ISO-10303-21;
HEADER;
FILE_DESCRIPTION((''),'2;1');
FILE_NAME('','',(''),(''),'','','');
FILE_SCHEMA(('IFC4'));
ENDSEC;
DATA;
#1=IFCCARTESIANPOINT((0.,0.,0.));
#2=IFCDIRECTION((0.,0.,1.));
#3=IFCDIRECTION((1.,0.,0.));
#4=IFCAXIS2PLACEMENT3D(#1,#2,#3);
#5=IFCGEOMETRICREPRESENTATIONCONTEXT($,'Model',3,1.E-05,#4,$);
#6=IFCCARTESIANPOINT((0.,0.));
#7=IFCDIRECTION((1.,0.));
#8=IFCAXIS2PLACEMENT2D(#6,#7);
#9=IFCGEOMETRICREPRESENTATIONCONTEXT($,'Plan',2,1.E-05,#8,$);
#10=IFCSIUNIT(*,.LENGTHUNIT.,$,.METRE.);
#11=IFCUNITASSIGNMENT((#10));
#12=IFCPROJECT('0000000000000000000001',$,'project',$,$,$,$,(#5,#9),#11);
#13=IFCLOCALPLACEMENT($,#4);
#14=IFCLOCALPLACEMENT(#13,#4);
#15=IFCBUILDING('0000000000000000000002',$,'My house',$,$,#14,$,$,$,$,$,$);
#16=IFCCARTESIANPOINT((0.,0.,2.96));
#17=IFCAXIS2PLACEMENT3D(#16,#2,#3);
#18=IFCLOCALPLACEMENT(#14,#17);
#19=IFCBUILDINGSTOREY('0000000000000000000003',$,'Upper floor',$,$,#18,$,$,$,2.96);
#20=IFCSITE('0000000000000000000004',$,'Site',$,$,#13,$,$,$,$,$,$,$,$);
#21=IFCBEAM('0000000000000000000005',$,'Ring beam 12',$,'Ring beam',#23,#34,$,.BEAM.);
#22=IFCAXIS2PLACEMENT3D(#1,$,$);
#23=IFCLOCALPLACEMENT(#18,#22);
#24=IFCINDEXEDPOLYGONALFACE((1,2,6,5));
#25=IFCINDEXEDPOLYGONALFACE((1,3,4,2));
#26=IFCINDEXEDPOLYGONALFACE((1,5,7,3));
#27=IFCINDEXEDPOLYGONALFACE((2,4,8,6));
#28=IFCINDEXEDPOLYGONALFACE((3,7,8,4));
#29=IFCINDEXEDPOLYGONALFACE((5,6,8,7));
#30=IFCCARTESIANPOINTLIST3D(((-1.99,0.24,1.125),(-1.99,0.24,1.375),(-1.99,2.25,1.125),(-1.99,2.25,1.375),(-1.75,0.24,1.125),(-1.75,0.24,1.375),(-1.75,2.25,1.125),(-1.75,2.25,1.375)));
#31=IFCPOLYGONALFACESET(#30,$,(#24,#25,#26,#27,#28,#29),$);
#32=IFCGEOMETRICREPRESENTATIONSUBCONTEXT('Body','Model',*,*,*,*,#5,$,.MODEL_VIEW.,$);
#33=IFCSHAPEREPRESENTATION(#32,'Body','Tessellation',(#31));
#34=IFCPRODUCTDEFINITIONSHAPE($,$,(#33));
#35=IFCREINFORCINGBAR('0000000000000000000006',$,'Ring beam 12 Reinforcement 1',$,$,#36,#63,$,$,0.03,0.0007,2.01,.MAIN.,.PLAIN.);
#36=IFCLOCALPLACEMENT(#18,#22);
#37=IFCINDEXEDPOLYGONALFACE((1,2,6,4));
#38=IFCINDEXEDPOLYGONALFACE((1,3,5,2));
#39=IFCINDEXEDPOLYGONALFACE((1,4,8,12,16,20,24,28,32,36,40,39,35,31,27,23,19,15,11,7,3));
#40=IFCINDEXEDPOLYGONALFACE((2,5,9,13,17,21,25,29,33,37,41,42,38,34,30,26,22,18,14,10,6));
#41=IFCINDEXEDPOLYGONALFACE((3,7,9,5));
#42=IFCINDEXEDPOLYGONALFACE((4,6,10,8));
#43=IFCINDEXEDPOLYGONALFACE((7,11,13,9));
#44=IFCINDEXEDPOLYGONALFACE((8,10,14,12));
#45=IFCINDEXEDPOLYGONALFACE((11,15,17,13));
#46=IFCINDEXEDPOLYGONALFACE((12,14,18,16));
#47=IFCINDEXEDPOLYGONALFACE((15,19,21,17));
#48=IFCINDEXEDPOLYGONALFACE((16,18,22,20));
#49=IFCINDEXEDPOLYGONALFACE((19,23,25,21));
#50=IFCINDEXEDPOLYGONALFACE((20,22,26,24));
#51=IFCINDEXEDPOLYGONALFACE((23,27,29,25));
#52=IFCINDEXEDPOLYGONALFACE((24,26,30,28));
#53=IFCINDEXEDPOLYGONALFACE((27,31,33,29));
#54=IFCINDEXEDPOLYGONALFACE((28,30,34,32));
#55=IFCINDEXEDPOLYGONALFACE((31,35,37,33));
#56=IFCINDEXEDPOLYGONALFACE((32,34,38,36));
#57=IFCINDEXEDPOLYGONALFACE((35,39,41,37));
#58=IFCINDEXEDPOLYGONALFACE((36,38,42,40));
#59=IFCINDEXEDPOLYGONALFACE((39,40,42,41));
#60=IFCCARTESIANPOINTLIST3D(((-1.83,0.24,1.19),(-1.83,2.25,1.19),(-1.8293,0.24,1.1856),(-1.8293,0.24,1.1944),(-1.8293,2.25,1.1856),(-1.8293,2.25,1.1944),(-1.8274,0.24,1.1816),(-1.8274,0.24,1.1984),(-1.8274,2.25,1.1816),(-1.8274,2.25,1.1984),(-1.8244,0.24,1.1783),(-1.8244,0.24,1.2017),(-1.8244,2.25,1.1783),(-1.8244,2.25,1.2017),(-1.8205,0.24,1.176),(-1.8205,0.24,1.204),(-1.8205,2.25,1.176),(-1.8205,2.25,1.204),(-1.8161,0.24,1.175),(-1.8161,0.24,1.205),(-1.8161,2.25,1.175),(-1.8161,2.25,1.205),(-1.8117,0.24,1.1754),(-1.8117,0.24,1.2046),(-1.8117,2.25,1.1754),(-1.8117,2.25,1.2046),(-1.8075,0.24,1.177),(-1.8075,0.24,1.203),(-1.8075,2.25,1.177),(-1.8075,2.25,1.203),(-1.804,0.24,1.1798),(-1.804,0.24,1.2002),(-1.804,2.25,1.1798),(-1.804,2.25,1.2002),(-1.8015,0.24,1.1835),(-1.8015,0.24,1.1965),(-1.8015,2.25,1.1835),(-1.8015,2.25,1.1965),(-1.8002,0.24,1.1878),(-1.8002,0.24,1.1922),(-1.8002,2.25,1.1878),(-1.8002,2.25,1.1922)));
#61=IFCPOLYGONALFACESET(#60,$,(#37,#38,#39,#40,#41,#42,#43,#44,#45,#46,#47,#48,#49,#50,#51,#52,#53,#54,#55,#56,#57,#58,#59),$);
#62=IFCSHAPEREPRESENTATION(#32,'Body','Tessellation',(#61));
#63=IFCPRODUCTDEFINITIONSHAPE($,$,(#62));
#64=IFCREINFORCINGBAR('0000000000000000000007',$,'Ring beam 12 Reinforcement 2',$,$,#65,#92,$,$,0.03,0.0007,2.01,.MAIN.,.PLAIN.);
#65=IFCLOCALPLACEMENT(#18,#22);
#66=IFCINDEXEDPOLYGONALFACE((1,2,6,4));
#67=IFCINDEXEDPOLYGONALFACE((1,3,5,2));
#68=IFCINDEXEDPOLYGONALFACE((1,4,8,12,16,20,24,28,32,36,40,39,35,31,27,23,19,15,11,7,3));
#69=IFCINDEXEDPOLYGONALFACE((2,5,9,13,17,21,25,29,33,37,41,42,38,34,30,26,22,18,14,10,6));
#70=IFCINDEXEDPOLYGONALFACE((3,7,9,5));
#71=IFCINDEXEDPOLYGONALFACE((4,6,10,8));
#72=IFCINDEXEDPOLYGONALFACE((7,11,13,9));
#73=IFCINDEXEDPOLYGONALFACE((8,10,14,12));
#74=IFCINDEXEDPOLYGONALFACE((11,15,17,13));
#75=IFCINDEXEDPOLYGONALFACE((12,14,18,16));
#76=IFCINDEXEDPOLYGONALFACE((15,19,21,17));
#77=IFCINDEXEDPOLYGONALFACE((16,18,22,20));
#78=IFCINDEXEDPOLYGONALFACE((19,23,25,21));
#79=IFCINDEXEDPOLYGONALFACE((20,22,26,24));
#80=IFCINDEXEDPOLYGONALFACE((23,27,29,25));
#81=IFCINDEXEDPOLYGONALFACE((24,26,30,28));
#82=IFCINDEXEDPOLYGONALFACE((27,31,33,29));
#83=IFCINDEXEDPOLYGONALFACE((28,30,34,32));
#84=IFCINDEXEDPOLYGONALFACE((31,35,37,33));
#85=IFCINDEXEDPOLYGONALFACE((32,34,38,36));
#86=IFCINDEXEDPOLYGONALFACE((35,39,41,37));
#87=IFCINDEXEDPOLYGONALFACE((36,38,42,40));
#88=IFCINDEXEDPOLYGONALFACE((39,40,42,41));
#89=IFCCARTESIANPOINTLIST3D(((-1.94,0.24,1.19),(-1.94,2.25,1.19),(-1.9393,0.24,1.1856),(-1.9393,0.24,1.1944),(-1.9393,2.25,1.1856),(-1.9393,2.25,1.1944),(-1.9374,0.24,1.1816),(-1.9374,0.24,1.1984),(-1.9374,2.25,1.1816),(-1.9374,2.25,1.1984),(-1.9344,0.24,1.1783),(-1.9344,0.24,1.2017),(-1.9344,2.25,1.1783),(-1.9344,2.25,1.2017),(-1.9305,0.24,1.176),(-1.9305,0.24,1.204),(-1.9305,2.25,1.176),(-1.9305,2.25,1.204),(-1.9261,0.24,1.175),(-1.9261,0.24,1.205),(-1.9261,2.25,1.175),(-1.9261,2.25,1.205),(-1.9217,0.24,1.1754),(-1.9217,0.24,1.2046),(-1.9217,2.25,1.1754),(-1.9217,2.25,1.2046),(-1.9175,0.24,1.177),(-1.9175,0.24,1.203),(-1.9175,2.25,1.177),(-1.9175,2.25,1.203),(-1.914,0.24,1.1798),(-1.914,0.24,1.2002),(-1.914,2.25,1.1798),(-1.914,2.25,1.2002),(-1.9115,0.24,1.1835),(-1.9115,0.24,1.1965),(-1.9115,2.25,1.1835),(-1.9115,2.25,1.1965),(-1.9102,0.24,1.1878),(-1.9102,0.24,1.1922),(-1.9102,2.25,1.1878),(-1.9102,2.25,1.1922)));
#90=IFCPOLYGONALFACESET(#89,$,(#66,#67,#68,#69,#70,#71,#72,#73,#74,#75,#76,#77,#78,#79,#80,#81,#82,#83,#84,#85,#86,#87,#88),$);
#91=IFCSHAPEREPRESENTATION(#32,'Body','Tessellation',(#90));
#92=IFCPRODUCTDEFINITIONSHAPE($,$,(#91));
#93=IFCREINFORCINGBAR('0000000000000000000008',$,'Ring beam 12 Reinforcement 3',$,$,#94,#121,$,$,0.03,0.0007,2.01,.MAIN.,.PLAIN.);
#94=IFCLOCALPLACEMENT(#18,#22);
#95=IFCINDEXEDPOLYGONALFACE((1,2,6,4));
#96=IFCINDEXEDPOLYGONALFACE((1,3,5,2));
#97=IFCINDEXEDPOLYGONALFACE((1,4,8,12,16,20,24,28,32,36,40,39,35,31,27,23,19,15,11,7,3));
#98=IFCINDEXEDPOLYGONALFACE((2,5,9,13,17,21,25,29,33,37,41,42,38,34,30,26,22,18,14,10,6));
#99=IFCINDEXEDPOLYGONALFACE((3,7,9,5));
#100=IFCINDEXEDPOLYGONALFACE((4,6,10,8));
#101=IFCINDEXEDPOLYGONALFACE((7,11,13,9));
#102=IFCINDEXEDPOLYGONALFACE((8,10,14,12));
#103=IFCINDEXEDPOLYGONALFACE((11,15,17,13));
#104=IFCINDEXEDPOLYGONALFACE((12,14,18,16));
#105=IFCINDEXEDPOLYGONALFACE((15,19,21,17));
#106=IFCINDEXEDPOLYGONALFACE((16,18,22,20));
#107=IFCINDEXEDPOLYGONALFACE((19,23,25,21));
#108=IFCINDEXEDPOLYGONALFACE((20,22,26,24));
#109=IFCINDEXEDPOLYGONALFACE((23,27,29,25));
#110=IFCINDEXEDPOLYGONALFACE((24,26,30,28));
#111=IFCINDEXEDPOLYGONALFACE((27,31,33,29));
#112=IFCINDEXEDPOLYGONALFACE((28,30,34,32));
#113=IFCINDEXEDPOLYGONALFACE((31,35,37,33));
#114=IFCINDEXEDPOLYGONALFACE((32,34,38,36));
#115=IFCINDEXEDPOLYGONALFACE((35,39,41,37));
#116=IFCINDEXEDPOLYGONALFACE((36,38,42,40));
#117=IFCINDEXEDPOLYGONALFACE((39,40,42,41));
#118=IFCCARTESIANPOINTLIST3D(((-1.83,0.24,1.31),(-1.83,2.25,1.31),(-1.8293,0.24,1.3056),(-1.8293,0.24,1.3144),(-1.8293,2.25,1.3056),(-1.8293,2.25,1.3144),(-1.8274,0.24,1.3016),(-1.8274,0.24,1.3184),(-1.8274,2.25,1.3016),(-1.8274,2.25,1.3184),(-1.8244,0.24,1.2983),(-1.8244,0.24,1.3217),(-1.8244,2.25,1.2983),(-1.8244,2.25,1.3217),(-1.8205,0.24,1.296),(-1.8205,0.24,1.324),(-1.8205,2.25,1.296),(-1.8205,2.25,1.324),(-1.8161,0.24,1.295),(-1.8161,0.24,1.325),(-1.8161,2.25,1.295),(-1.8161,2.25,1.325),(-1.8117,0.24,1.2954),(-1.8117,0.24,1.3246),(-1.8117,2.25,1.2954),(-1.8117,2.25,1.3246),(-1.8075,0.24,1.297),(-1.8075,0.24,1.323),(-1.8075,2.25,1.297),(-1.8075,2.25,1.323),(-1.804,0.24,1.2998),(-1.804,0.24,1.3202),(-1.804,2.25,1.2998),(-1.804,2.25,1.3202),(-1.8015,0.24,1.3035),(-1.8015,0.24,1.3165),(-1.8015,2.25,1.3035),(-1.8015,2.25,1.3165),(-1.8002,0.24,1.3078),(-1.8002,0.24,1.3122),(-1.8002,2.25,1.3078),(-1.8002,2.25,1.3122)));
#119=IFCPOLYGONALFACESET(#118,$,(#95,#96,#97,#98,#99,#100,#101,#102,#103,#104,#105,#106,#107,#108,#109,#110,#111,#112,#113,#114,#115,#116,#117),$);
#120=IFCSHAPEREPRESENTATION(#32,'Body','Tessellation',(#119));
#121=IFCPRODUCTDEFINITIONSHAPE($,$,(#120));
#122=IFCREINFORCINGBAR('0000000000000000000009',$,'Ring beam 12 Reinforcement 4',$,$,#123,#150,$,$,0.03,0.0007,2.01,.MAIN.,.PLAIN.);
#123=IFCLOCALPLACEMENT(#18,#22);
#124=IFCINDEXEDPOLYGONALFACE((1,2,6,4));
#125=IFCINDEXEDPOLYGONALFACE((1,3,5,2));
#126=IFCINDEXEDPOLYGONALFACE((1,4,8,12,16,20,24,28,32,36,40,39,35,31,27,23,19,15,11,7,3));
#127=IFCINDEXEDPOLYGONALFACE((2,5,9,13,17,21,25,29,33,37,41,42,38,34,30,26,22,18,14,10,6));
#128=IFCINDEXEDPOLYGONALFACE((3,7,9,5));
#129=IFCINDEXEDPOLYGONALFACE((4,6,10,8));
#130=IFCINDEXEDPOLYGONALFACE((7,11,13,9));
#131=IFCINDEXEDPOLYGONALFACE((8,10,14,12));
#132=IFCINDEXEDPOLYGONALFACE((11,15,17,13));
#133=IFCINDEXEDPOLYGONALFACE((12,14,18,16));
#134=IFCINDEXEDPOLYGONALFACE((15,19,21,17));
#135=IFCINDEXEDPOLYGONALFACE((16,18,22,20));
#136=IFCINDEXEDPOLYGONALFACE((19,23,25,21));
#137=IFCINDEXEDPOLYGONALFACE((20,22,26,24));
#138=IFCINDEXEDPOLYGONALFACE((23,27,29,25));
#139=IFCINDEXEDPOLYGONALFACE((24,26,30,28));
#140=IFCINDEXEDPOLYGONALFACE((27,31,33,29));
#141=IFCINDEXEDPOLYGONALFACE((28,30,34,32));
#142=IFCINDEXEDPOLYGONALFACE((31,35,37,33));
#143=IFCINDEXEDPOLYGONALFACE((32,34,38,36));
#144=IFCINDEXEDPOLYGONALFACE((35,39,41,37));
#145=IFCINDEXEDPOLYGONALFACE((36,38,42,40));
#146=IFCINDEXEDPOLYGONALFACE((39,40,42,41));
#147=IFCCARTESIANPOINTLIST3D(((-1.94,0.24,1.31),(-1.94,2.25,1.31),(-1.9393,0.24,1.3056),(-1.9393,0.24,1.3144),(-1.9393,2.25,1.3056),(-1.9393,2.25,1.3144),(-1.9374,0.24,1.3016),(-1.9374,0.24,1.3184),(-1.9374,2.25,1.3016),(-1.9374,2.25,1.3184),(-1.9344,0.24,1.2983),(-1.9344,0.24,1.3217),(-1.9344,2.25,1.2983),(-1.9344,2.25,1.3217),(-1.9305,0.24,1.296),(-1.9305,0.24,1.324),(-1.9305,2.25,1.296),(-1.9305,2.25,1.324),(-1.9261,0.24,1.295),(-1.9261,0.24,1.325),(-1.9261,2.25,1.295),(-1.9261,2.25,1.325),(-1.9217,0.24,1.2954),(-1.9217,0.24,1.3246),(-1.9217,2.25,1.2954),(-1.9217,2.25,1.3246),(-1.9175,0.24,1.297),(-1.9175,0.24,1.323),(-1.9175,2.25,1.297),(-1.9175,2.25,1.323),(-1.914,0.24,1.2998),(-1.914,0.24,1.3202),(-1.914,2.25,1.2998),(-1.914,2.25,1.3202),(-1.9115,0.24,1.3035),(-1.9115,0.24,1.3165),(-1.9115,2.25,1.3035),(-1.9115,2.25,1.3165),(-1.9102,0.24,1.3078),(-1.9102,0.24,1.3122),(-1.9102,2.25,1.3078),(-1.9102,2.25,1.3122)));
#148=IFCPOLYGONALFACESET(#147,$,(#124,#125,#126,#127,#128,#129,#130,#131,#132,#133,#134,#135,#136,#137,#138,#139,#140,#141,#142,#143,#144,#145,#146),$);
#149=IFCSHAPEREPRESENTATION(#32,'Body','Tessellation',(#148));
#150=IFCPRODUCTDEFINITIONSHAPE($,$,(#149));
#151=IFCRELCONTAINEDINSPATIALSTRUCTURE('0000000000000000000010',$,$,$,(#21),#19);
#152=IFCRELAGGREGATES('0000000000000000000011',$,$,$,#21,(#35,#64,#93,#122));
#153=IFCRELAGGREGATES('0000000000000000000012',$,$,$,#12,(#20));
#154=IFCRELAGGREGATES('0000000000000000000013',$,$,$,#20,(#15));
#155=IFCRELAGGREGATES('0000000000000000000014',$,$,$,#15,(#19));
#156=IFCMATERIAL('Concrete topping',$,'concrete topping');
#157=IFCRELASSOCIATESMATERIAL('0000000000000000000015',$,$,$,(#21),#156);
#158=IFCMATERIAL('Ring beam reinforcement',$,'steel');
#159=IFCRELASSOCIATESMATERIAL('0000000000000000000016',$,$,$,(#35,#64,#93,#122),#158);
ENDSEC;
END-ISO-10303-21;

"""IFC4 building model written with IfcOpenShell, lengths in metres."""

from ifc_helpers import new_model, si_unit, frame, origin_with_axes, origin_2d, origin_2d_with_axis, place, context, subcontext, project, spatial, circle_curve, rectangle, outline, extrude, source, transform, mapped, material, element, aggregate, save


model = new_model("IFC4")

# Units and contexts
model_context = context("Model", 3, precision=1e-05, world=origin_with_axes())
plan_context = context("Plan", 2, precision=1e-05, world=origin_2d_with_axis())
body_context = subcontext(model_context, "Body", "Model", "MODEL_VIEW")
ifc_project = project(units=[si_unit("LENGTHUNIT", "METRE")], contexts=[model_context, plan_context])

# Site, building, storey
site_placement = place(None, origin_with_axes())
site = spatial("IfcSite", under=ifc_project, at=site_placement, Name="Site")
building_placement = place(site_placement, origin_with_axes())
building = spatial("IfcBuilding", under=site, at=building_placement, Name="My house")
storey_placement = place(building_placement, frame((0.0, 0.0, 2.96), z_axis=(0.0, 0.0, 1.0), x_axis=(1.0, 0.0, 0.0)))
storey = spatial("IfcBuildingStorey", under=building, at=storey_placement, Name="Upper floor", Elevation=2.96)

# Beam
ifc_material_1 = material(Name="Concrete topping", Category="concrete topping")
shared_shape_1 = source(origin_with_axes(), body_context, "Body", "SweptSolid", [
    extrude(rectangle(XDim=0.24, YDim=0.25), frame((0.0, 0.0, 0.0), z_axis=(1.0, 0.0, 0.0), x_axis=(0.0, 1.0, 0.0)), (0.0, 0.0, 1.0), 2.01),
])
beam_1_placement = place(storey_placement, frame((-1.87, 2.25, 1.25), z_axis=(0.0, 0.0, 1.0), x_axis=(0.0, 1.0, 0.0)))
beam_1 = element("IfcBeam", 1, at=beam_1_placement, inside=storey, material=ifc_material_1, Name="Ring beam 12", ObjectType="Ring beam", PredefinedType="BEAM", context=body_context, shape_type="MappedRepresentation", body=[
    mapped(shared_shape_1, transform((0.0, 0.0, 0.0), x_axis=(-1.0, 0.0, 0.0), y_axis=(0.0, 1.0, 0.0), z_axis=(0.0, 0.0, 1.0), scale=1.0)),
])

# Reinforcing bars
ifc_material_2 = material(Name="Ring beam reinforcement", Category="steel")
shared_shape_2 = source(origin_with_axes(), body_context, "Body", "SweptSolid", [
    extrude(outline(circle_curve(origin_2d(), 0.015)), frame((0.0, 0.0, 0.0), z_axis=(1.0, 0.0, 0.0), x_axis=(0.0, 1.0, 0.0)), (0.0, 0.0, 1.0), 2.01),
])
reinforcing_bar_1_placement = place(beam_1_placement, frame((0.0, -0.055, -0.06), z_axis=(0.0, 0.0, 1.0), x_axis=(1.0, 0.0, 0.0)))
reinforcing_bar_1 = element("IfcReinforcingBar", 2, at=reinforcing_bar_1_placement, material=ifc_material_2, Name="Ring beam 12 Reinforcement 1", BarLength=2.01, BarSurface="PLAIN", CrossSectionArea=0.0007, NominalDiameter=0.03, PredefinedType="MAIN", context=body_context, shape_type="MappedRepresentation", body=[
    mapped(shared_shape_2, transform((0.0, 0.0, 0.0), x_axis=(-1.0, 0.0, 0.0), y_axis=(0.0, 1.0, 0.0), z_axis=(0.0, 0.0, 1.0), scale=1.0)),
])
shared_shape_3 = source(origin_with_axes(), body_context, "Body", "SweptSolid", [
    extrude(outline(circle_curve(origin_2d(), 0.015)), frame((0.0, 0.0, 0.0), z_axis=(1.0, 0.0, 0.0), x_axis=(0.0, 1.0, 0.0)), (0.0, 0.0, 1.0), 2.01),
])
reinforcing_bar_2_placement = place(beam_1_placement, frame((0.0, 0.055, -0.06), z_axis=(0.0, 0.0, 1.0), x_axis=(1.0, 0.0, 0.0)))
reinforcing_bar_2 = element("IfcReinforcingBar", 3, at=reinforcing_bar_2_placement, material=ifc_material_2, Name="Ring beam 12 Reinforcement 2", BarLength=2.01, BarSurface="PLAIN", CrossSectionArea=0.0007, NominalDiameter=0.03, PredefinedType="MAIN", context=body_context, shape_type="MappedRepresentation", body=[
    mapped(shared_shape_3, transform((0.0, 0.0, 0.0), x_axis=(-1.0, 0.0, 0.0), y_axis=(0.0, 1.0, 0.0), z_axis=(0.0, 0.0, 1.0), scale=1.0)),
])
shared_shape_4 = source(origin_with_axes(), body_context, "Body", "SweptSolid", [
    extrude(outline(circle_curve(origin_2d(), 0.015)), frame((0.0, 0.0, 0.0), z_axis=(1.0, 0.0, 0.0), x_axis=(0.0, 1.0, 0.0)), (0.0, 0.0, 1.0), 2.01),
])
reinforcing_bar_3_placement = place(beam_1_placement, frame((0.0, -0.055, 0.06), z_axis=(0.0, 0.0, 1.0), x_axis=(1.0, 0.0, 0.0)))
reinforcing_bar_3 = element("IfcReinforcingBar", 4, at=reinforcing_bar_3_placement, material=ifc_material_2, Name="Ring beam 12 Reinforcement 3", BarLength=2.01, BarSurface="PLAIN", CrossSectionArea=0.0007, NominalDiameter=0.03, PredefinedType="MAIN", context=body_context, shape_type="MappedRepresentation", body=[
    mapped(shared_shape_4, transform((0.0, 0.0, 0.0), x_axis=(-1.0, 0.0, 0.0), y_axis=(0.0, 1.0, 0.0), z_axis=(0.0, 0.0, 1.0), scale=1.0)),
])
shared_shape_5 = source(origin_with_axes(), body_context, "Body", "SweptSolid", [
    extrude(outline(circle_curve(origin_2d(), 0.015)), frame((0.0, 0.0, 0.0), z_axis=(1.0, 0.0, 0.0), x_axis=(0.0, 1.0, 0.0)), (0.0, 0.0, 1.0), 2.01),
])
reinforcing_bar_4_placement = place(beam_1_placement, frame((0.0, 0.055, 0.06), z_axis=(0.0, 0.0, 1.0), x_axis=(1.0, 0.0, 0.0)))
reinforcing_bar_4 = element("IfcReinforcingBar", 5, at=reinforcing_bar_4_placement, material=ifc_material_2, Name="Ring beam 12 Reinforcement 4", BarLength=2.01, BarSurface="PLAIN", CrossSectionArea=0.0007, NominalDiameter=0.03, PredefinedType="MAIN", context=body_context, shape_type="MappedRepresentation", body=[
    mapped(shared_shape_5, transform((0.0, 0.0, 0.0), x_axis=(-1.0, 0.0, 0.0), y_axis=(0.0, 1.0, 0.0), z_axis=(0.0, 0.0, 1.0), scale=1.0)),
])
aggregate(beam_1, [reinforcing_bar_1, reinforcing_bar_2, reinforcing_bar_3, reinforcing_bar_4])

save(model, "model.ifc")
